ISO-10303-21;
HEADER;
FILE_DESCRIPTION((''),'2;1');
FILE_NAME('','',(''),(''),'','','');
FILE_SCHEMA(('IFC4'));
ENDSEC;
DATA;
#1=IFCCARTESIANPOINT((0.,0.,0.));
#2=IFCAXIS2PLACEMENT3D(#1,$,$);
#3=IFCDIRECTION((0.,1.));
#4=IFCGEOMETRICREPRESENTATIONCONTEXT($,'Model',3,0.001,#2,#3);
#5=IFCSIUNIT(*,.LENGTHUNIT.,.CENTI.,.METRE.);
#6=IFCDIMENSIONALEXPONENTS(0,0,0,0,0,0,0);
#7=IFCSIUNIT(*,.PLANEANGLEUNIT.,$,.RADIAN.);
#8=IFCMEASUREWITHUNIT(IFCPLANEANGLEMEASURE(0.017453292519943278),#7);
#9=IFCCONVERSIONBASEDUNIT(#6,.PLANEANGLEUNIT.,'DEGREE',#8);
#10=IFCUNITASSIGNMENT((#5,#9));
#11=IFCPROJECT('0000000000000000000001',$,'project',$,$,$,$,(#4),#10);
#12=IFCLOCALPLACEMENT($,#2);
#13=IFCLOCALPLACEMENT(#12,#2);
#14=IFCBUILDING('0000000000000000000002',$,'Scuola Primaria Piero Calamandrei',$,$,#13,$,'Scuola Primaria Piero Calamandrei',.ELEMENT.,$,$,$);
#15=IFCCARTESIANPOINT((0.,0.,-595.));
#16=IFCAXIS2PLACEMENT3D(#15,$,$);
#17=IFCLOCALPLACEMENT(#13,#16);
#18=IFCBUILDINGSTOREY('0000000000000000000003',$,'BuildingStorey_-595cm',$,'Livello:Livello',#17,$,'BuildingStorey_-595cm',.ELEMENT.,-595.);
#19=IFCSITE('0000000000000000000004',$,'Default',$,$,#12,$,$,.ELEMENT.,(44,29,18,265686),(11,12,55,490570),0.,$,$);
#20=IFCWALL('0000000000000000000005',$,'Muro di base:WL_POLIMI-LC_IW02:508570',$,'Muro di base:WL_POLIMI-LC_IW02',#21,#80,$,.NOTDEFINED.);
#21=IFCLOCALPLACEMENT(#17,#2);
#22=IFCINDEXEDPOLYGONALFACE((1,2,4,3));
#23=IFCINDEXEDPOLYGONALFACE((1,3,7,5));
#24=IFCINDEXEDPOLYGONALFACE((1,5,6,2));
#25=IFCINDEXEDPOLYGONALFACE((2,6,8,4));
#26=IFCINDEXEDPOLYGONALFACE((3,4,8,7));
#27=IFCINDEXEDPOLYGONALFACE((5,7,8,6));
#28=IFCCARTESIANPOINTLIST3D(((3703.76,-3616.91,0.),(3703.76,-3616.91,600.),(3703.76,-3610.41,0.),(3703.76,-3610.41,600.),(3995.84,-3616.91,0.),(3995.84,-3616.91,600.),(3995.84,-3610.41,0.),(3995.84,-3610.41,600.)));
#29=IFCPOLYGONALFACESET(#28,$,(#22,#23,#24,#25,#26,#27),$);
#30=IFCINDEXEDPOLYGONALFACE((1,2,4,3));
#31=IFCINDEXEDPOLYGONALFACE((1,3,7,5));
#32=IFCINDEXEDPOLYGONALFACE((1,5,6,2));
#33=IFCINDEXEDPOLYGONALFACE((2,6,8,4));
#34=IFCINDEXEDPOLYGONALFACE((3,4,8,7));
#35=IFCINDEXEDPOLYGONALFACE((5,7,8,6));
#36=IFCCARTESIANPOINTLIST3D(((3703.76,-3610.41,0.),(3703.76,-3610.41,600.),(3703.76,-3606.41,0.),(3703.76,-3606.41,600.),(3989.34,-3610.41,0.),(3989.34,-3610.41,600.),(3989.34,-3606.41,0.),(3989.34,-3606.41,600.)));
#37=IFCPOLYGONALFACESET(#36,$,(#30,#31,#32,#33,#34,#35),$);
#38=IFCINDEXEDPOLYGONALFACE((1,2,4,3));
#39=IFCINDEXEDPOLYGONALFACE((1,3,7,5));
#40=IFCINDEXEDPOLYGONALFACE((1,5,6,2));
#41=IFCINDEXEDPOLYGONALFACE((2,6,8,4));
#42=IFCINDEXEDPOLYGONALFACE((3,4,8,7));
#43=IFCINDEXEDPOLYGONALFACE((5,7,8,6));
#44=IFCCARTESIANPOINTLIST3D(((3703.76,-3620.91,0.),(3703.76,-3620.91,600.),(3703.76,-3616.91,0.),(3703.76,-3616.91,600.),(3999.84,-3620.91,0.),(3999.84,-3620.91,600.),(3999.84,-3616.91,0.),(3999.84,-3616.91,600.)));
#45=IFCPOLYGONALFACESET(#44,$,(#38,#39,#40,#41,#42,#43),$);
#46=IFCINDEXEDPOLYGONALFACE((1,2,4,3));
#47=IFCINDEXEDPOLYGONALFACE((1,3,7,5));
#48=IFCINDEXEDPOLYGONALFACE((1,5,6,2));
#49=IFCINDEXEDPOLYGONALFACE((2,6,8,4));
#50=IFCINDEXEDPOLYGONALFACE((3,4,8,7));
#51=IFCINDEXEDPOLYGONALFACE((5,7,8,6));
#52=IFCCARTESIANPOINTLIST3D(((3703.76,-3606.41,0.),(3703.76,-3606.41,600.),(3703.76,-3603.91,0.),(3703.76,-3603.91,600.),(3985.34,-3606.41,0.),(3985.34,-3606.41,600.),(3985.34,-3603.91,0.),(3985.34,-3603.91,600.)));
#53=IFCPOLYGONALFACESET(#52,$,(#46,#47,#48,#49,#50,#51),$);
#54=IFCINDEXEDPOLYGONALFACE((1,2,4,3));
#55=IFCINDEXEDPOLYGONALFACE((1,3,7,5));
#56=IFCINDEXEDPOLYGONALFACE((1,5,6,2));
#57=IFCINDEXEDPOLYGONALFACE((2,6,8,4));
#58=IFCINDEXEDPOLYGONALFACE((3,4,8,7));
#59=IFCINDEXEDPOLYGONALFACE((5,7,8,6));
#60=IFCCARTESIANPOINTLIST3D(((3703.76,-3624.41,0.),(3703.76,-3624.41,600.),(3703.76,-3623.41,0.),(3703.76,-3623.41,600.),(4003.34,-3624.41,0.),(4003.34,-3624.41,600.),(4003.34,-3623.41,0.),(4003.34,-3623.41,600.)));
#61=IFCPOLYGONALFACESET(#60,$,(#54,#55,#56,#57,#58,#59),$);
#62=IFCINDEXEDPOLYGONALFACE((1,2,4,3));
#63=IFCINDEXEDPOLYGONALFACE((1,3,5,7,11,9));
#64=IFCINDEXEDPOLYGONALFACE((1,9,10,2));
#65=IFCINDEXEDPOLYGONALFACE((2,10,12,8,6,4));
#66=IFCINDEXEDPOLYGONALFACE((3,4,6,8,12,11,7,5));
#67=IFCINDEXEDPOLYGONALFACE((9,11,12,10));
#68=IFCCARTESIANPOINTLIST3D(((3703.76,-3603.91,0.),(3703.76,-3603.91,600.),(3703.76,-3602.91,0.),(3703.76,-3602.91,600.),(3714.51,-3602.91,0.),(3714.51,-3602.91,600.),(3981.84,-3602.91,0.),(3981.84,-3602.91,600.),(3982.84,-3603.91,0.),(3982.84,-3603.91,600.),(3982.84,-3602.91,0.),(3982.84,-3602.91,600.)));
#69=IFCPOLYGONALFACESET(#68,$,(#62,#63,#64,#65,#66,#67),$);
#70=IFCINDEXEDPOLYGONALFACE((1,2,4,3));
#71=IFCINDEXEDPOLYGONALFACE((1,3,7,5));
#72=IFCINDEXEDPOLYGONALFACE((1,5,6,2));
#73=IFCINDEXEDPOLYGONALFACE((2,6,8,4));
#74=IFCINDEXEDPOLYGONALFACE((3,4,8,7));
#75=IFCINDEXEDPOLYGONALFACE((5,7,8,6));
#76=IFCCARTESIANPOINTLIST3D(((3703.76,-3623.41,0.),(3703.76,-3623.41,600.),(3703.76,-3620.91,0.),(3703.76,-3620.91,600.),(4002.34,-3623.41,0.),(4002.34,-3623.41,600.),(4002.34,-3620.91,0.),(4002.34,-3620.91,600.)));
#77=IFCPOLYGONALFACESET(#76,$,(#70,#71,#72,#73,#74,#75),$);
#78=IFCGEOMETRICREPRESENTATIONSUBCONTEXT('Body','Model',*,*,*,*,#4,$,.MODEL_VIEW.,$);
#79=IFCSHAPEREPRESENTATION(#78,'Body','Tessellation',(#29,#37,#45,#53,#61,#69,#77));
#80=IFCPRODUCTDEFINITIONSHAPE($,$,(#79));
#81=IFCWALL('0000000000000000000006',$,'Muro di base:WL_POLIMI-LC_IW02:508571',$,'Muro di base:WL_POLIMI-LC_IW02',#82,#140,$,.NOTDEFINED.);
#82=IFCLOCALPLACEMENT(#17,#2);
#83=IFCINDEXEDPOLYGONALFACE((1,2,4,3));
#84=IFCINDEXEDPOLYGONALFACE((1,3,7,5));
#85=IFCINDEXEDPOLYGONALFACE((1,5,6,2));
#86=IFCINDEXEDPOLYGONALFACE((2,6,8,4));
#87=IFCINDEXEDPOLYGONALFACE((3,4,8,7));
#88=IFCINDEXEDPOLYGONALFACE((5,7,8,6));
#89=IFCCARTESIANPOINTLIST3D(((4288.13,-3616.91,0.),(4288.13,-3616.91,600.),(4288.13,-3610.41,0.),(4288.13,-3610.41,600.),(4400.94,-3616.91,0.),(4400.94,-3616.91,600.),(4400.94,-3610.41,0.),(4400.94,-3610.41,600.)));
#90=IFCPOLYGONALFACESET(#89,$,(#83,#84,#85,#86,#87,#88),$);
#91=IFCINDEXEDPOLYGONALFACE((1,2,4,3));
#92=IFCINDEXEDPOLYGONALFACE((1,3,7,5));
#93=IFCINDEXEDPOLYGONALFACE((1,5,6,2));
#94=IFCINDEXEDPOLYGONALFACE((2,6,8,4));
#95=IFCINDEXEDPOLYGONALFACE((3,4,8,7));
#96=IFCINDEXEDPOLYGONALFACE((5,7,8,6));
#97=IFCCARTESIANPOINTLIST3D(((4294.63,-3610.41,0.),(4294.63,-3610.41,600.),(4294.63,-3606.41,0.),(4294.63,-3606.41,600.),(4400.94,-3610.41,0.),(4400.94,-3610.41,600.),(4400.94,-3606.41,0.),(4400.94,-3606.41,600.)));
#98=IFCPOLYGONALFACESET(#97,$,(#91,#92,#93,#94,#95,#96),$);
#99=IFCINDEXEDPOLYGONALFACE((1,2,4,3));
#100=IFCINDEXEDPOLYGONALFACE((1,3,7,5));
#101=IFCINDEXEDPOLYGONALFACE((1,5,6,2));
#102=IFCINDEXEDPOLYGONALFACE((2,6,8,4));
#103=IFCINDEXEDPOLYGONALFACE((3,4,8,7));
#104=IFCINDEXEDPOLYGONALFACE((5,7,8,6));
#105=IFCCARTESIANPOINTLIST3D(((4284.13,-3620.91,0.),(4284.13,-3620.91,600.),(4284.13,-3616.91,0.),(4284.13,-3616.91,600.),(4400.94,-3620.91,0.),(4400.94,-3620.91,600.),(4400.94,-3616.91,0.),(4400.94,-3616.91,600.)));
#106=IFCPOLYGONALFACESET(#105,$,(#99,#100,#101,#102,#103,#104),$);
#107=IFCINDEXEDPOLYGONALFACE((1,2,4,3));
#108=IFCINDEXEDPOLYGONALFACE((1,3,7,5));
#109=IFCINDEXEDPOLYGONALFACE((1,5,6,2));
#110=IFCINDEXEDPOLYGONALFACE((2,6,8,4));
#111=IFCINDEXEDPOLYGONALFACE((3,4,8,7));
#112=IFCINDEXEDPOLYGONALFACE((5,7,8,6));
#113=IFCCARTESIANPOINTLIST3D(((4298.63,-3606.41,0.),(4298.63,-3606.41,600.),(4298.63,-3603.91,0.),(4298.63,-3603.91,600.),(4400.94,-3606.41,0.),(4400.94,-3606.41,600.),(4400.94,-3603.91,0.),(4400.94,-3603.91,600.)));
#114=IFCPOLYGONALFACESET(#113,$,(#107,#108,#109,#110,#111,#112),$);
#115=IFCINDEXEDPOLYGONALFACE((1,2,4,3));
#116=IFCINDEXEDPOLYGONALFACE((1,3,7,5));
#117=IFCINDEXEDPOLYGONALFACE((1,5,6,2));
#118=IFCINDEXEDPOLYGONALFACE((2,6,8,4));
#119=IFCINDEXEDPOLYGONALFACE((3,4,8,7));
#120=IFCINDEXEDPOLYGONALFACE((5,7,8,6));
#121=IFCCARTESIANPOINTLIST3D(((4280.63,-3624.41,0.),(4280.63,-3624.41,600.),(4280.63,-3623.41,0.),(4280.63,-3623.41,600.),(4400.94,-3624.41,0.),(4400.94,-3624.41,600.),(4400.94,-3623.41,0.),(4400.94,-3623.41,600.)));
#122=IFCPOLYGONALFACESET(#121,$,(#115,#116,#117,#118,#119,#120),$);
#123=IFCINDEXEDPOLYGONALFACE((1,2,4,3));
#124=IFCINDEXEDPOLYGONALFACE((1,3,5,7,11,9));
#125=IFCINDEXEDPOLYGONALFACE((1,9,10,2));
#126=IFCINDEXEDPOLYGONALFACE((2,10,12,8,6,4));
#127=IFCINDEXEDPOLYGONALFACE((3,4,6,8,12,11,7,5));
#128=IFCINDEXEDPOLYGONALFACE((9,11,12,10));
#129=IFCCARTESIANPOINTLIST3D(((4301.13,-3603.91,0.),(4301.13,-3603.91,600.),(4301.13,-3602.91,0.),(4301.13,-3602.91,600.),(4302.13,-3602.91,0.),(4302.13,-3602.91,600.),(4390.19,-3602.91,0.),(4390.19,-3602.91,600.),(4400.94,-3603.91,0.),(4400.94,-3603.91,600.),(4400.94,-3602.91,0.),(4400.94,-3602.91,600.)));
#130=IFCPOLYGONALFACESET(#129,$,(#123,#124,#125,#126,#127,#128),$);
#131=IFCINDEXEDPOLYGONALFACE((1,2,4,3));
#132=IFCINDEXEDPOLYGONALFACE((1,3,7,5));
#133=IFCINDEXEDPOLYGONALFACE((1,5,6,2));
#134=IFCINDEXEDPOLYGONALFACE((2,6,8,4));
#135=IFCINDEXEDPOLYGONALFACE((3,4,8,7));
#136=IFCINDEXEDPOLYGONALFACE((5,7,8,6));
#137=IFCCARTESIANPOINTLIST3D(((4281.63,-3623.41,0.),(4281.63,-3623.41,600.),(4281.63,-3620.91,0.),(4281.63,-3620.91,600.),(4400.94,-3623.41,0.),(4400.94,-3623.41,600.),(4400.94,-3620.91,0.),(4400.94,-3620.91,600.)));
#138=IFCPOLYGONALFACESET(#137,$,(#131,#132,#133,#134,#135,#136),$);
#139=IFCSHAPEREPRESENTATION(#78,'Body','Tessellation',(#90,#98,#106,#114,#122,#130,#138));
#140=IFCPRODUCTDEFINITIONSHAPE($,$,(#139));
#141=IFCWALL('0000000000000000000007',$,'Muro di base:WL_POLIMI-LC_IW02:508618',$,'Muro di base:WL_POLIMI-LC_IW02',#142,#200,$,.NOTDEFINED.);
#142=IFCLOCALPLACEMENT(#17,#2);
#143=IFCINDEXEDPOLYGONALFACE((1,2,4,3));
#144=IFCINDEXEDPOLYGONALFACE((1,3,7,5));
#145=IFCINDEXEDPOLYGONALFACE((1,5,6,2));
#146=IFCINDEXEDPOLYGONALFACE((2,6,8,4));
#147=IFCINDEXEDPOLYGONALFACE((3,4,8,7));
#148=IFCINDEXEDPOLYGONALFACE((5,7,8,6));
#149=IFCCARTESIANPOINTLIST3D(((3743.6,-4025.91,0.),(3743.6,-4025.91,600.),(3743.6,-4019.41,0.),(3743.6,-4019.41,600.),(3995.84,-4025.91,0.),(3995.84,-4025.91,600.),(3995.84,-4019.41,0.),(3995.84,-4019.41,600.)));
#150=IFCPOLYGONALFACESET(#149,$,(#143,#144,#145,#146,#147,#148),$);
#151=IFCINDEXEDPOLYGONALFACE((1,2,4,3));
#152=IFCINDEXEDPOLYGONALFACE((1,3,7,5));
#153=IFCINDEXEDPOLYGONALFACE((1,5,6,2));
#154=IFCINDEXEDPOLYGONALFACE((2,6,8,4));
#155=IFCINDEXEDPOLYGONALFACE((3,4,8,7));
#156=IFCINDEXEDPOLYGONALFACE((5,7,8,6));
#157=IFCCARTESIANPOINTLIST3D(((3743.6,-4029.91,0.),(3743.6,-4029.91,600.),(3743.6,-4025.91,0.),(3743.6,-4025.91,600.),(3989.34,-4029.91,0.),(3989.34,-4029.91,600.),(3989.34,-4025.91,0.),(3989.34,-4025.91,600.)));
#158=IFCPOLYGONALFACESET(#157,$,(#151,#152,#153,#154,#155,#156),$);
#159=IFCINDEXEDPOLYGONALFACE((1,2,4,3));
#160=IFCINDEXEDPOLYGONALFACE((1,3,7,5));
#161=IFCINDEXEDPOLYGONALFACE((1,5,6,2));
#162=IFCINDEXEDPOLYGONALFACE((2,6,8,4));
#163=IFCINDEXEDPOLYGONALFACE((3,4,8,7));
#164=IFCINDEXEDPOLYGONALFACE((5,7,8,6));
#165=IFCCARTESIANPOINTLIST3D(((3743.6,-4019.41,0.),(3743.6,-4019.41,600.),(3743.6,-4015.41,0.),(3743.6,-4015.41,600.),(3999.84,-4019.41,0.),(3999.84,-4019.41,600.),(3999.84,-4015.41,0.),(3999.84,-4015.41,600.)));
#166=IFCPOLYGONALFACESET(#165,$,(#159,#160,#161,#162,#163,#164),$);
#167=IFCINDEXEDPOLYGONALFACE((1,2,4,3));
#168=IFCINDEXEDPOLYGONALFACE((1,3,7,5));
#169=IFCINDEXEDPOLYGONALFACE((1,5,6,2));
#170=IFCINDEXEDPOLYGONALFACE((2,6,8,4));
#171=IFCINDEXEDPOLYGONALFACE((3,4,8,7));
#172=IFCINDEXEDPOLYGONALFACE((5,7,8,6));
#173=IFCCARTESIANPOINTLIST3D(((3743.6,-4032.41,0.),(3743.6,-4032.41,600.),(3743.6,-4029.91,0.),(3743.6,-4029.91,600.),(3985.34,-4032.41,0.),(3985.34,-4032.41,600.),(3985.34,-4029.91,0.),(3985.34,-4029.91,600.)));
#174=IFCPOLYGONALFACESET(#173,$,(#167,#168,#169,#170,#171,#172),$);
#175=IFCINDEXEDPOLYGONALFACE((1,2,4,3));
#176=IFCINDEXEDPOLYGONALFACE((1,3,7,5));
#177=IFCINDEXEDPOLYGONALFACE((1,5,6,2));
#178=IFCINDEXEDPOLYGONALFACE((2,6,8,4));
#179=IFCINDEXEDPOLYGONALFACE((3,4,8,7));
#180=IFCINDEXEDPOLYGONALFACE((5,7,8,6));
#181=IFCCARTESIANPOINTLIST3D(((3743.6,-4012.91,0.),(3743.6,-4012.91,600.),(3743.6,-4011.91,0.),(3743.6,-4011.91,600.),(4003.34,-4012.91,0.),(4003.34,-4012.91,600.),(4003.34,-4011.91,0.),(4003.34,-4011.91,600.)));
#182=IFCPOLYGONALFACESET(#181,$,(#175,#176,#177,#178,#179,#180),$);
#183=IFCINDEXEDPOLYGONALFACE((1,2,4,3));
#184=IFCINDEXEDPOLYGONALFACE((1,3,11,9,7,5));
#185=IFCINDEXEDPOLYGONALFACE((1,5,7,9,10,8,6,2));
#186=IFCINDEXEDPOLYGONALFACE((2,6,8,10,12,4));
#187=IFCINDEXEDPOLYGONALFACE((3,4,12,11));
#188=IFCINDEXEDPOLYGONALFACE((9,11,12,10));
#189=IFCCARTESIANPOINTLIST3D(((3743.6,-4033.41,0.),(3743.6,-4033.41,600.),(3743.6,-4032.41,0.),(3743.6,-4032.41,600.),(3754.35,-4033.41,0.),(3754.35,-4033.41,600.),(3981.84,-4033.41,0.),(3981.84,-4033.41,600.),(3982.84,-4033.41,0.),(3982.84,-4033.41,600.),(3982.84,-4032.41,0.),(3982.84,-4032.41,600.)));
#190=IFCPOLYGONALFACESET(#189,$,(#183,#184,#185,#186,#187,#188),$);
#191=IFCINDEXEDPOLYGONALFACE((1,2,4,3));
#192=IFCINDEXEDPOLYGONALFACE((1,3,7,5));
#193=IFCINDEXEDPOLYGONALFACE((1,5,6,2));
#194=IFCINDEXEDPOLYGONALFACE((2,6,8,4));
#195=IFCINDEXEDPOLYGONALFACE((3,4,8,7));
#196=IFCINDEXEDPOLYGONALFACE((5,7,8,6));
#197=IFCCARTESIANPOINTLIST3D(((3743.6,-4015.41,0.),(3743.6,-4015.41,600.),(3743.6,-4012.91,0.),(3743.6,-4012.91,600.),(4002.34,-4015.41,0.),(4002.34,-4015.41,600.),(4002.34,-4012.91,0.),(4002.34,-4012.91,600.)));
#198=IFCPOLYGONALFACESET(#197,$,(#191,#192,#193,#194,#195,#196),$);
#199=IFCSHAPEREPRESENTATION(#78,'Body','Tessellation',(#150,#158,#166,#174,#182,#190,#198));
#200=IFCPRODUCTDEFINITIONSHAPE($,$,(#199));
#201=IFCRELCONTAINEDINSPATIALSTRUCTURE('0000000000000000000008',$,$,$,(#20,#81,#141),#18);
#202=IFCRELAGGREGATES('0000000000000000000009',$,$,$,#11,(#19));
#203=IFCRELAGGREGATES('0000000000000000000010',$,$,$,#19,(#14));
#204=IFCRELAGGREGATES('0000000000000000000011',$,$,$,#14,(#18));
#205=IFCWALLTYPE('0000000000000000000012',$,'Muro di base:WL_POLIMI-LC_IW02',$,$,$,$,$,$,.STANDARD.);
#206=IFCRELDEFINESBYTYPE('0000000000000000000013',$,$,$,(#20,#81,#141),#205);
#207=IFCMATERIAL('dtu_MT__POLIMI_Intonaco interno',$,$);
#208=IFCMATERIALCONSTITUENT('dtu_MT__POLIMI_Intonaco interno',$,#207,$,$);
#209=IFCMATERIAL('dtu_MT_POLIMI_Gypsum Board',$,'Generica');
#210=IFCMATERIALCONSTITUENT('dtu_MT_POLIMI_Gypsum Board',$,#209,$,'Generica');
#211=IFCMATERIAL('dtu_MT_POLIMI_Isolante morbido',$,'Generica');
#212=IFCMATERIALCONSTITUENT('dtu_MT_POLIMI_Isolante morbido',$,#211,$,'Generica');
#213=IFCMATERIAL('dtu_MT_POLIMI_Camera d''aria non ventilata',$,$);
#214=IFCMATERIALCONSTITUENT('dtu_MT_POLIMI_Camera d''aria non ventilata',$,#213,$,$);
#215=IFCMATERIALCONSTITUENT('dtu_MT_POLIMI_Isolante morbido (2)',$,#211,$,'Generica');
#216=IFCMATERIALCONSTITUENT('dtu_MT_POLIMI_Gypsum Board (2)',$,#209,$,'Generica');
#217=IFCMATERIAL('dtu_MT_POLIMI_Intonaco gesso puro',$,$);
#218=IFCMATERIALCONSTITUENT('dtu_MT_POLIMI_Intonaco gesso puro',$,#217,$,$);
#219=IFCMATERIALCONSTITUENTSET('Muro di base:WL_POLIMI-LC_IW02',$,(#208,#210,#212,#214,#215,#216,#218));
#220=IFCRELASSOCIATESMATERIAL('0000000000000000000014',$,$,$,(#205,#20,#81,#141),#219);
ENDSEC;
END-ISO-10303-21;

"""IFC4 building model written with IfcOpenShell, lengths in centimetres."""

from ifc_helpers import new_model, entity, si_unit, converted_unit, direction, frame, origin, place, context, subcontext, project, spatial, indexed_curve, outline, extrude, material, constituent, constituent_set, type_object, element, save


model = new_model("IFC4")

# Units and contexts
model_context = context("Model", 3, precision=0.001, world=origin(), true_north=direction((0.0, 1.0)))
body_context = subcontext(model_context, "Body", "Model", "MODEL_VIEW")
ifc_project = project(units=[si_unit("LENGTHUNIT", "METRE", prefix="CENTI"), converted_unit("PLANEANGLEUNIT", "DEGREE", entity("IfcPlaneAngleMeasure", 0.017453292519943278), si_unit("PLANEANGLEUNIT", "RADIAN"), dimensions=[0, 0, 0, 0, 0, 0, 0])], contexts=[model_context])

# Site, building, storey
site_placement = place(None, origin())
site = spatial("IfcSite", under=ifc_project, at=site_placement, Name="Default", CompositionType="ELEMENT", RefLatitude=(44, 29, 18, 265686), RefLongitude=(11, 12, 55, 490570), RefElevation=0.0)
building_placement = place(site_placement, origin())
building = spatial("IfcBuilding", under=site, at=building_placement, Name="Scuola Primaria Piero Calamandrei", LongName="Scuola Primaria Piero Calamandrei", CompositionType="ELEMENT")
storey_placement = place(building_placement, frame((0.0, 0.0, -595.0)))
storey = spatial("IfcBuildingStorey", under=building, at=storey_placement, Name="BuildingStorey_-595cm", ObjectType="Livello:Livello", LongName="BuildingStorey_-595cm", CompositionType="ELEMENT", Elevation=-595.0)

# Walls
ifc_material_1 = material(Name="dtu_MT__POLIMI_Intonaco interno")
ifc_constituent_1 = constituent(ifc_material_1, Name="dtu_MT__POLIMI_Intonaco interno")
ifc_material_2 = material(Name="dtu_MT_POLIMI_Gypsum Board", Category="Generica")
ifc_constituent_2 = constituent(ifc_material_2, Name="dtu_MT_POLIMI_Gypsum Board", Category="Generica")
ifc_material_3 = material(Name="dtu_MT_POLIMI_Isolante morbido", Category="Generica")
ifc_constituent_3 = constituent(ifc_material_3, Name="dtu_MT_POLIMI_Isolante morbido", Category="Generica")
ifc_material_4 = material(Name="dtu_MT_POLIMI_Camera d'aria non ventilata")
ifc_constituent_4 = constituent(ifc_material_4, Name="dtu_MT_POLIMI_Camera d'aria non ventilata")
ifc_constituent_5 = constituent(ifc_material_3, Name="dtu_MT_POLIMI_Isolante morbido (2)", Category="Generica")
ifc_constituent_6 = constituent(ifc_material_2, Name="dtu_MT_POLIMI_Gypsum Board (2)", Category="Generica")
ifc_material_5 = material(Name="dtu_MT_POLIMI_Intonaco gesso puro")
ifc_constituent_7 = constituent(ifc_material_5, Name="dtu_MT_POLIMI_Intonaco gesso puro")
ifc_constituent_set_1 = constituent_set(constituents=[ifc_constituent_1, ifc_constituent_2, ifc_constituent_3, ifc_constituent_4, ifc_constituent_5, ifc_constituent_6, ifc_constituent_7], Name="Muro di base:WL_POLIMI-LC_IW02")
wall_type_1 = type_object("IfcWallType", Name="Muro di base:WL_POLIMI-LC_IW02", PredefinedType="STANDARD", material=ifc_constituent_set_1)
wall_1_placement = place(storey_placement, frame((3703.76, -3613.66, 0.0)))
element("IfcWall", 1, at=wall_1_placement, inside=storey, type_object=wall_type_1, material=ifc_constituent_set_1, Name="Muro di base:WL_POLIMI-LC_IW02:508570", ObjectType="Muro di base:WL_POLIMI-LC_IW02", PredefinedType="NOTDEFINED", context=body_context, shape_type="SweptSolid", body=[
    extrude(outline(indexed_curve([(-146.04, -3.25), (146.04, -3.25), (146.04, 3.25), (-146.04, 3.25), (-146.04, -3.25)], self_intersect=False)), frame((146.04, 0.0, 0.0)), (0.0, 0.0, 1.0), 600.0),
    extrude(outline(indexed_curve([(-142.79, -2.0), (142.79, -2.0), (142.79, 2.0), (-142.79, 2.0), (-142.79, -2.0)], self_intersect=False)), frame((142.79, 5.25, 0.0)), (0.0, 0.0, 1.0), 600.0),
    extrude(outline(indexed_curve([(-148.04, -2.0), (148.04, -2.0), (148.04, 2.0), (-148.04, 2.0), (-148.04, -2.0)], self_intersect=False)), frame((148.04, -5.25, 0.0)), (0.0, 0.0, 1.0), 600.0),
    extrude(outline(indexed_curve([(-140.79, -1.25), (140.79, -1.25), (140.79, 1.25), (-140.79, 1.25), (-140.79, -1.25)], self_intersect=False)), frame((140.79, 8.5, 0.0)), (0.0, 0.0, 1.0), 600.0),
    extrude(outline(indexed_curve([(-0.5, -149.79), (0.5, -149.79), (0.5, 149.79), (-0.5, 149.79), (-0.5, -149.79)], self_intersect=False)), frame((149.79, -10.25, 0.0), z_axis=(0.0, 0.0, 1.0), x_axis=(0.0, 1.0, 0.0)), (0.0, 0.0, 1.0), 600.0),
    extrude(outline(indexed_curve([(-136.91, -0.33), (130.41, -0.33), (141.16, -0.33), (141.16, 0.67), (-137.91, 0.67), (-137.91, -0.33), (-136.91, -0.33)], self_intersect=False)), frame((141.16, 10.42, 0.0), z_axis=(0.0, 0.0, 1.0), x_axis=(-1.0, 0.0, 0.0)), (0.0, 0.0, 1.0), 600.0),
    extrude(outline(indexed_curve([(-149.29, -1.25), (149.29, -1.25), (149.29, 1.25), (-149.29, 1.25), (-149.29, -1.25)], self_intersect=False)), frame((149.29, -8.5, 0.0)), (0.0, 0.0, 1.0), 600.0),
])
wall_2_placement = place(storey_placement, frame((4280.63, -3613.66, 0.0)))
element("IfcWall", 2, at=wall_2_placement, inside=storey, type_object=wall_type_1, material=ifc_constituent_set_1, Name="Muro di base:WL_POLIMI-LC_IW02:508571", ObjectType="Muro di base:WL_POLIMI-LC_IW02", PredefinedType="NOTDEFINED", context=body_context, shape_type="SweptSolid", body=[
    extrude(outline(indexed_curve([(-56.4, -3.25), (56.4, -3.25), (56.4, 3.25), (-56.4, 3.25), (-56.4, -3.25)], self_intersect=False)), frame((63.9, 0.0, 0.0)), (0.0, 0.0, 1.0), 600.0),
    extrude(outline(indexed_curve([(-53.15, -2.0), (53.15, -2.0), (53.15, 2.0), (-53.15, 2.0), (-53.15, -2.0)], self_intersect=False)), frame((67.15, 5.25, 0.0)), (0.0, 0.0, 1.0), 600.0),
    extrude(outline(indexed_curve([(-58.4, -2.0), (58.4, -2.0), (58.4, 2.0), (-58.4, 2.0), (-58.4, -2.0)], self_intersect=False)), frame((61.9, -5.25, 0.0)), (0.0, 0.0, 1.0), 600.0),
    extrude(outline(indexed_curve([(-51.15, -1.25), (51.15, -1.25), (51.15, 1.25), (-51.15, 1.25), (-51.15, -1.25)], self_intersect=False)), frame((69.15, 8.5, 0.0)), (0.0, 0.0, 1.0), 600.0),
    extrude(outline(indexed_curve([(-0.5, -60.15), (0.5, -60.15), (0.5, 60.15), (-0.5, 60.15), (-0.5, -60.15)], self_intersect=False)), frame((60.15, -10.25, 0.0), z_axis=(0.0, 0.0, 1.0), x_axis=(0.0, 1.0, 0.0)), (0.0, 0.0, 1.0), 600.0),
    extrude(outline(indexed_curve([(-40.78, -0.33), (47.28, -0.33), (48.28, -0.33), (48.28, 0.67), (-51.53, 0.67), (-51.53, -0.33), (-40.78, -0.33)], self_intersect=False)), frame((68.78, 10.42, 0.0), z_axis=(0.0, 0.0, 1.0), x_axis=(-1.0, 0.0, 0.0)), (0.0, 0.0, 1.0), 600.0),
    extrude(outline(indexed_curve([(-59.65, -1.25), (59.65, -1.25), (59.65, 1.25), (-59.65, 1.25), (-59.65, -1.25)], self_intersect=False)), frame((60.65, -8.5, 0.0)), (0.0, 0.0, 1.0), 600.0),
])
wall_3_placement = place(storey_placement, frame((4003.34, -4022.66, 0.0), z_axis=(0.0, 0.0, 1.0), x_axis=(-1.0, 0.0, 0.0)))
element("IfcWall", 3, at=wall_3_placement, inside=storey, type_object=wall_type_1, material=ifc_constituent_set_1, Name="Muro di base:WL_POLIMI-LC_IW02:508618", ObjectType="Muro di base:WL_POLIMI-LC_IW02", PredefinedType="NOTDEFINED", context=body_context, shape_type="SweptSolid", body=[
    extrude(outline(indexed_curve([(-126.12, -3.25), (126.12, -3.25), (126.12, 3.25), (-126.12, 3.25), (-126.12, -3.25)], self_intersect=False)), frame((133.62, 0.0, 0.0)), (0.0, 0.0, 1.0), 600.0),
    extrude(outline(indexed_curve([(-122.87, -2.0), (122.87, -2.0), (122.87, 2.0), (-122.87, 2.0), (-122.87, -2.0)], self_intersect=False)), frame((136.87, 5.25, 0.0)), (0.0, 0.0, 1.0), 600.0),
    extrude(outline(indexed_curve([(-128.12, -2.0), (128.12, -2.0), (128.12, 2.0), (-128.12, 2.0), (-128.12, -2.0)], self_intersect=False)), frame((131.62, -5.25, 0.0)), (0.0, 0.0, 1.0), 600.0),
    extrude(outline(indexed_curve([(-120.87, -1.25), (120.87, -1.25), (120.87, 1.25), (-120.87, 1.25), (-120.87, -1.25)], self_intersect=False)), frame((138.87, 8.5, 0.0)), (0.0, 0.0, 1.0), 600.0),
    extrude(outline(indexed_curve([(-0.5, -129.87), (0.5, -129.87), (0.5, 129.87), (-0.5, 129.87), (-0.5, -129.87)], self_intersect=False)), frame((129.87, -10.25, 0.0), z_axis=(0.0, 0.0, 1.0), x_axis=(0.0, 1.0, 0.0)), (0.0, 0.0, 1.0), 600.0),
    extrude(outline(indexed_curve([(-110.5, -0.33), (117.0, -0.33), (118.0, -0.33), (118.0, 0.67), (-121.25, 0.67), (-121.25, -0.33), (-110.5, -0.33)], self_intersect=False)), frame((138.5, 10.42, 0.0), z_axis=(0.0, 0.0, 1.0), x_axis=(-1.0, 0.0, 0.0)), (0.0, 0.0, 1.0), 600.0),
    extrude(outline(indexed_curve([(-129.37, -1.25), (129.37, -1.25), (129.37, 1.25), (-129.37, 1.25), (-129.37, -1.25)], self_intersect=False)), frame((130.37, -8.5, 0.0)), (0.0, 0.0, 1.0), 600.0),
])

save(model, "model.ifc")
